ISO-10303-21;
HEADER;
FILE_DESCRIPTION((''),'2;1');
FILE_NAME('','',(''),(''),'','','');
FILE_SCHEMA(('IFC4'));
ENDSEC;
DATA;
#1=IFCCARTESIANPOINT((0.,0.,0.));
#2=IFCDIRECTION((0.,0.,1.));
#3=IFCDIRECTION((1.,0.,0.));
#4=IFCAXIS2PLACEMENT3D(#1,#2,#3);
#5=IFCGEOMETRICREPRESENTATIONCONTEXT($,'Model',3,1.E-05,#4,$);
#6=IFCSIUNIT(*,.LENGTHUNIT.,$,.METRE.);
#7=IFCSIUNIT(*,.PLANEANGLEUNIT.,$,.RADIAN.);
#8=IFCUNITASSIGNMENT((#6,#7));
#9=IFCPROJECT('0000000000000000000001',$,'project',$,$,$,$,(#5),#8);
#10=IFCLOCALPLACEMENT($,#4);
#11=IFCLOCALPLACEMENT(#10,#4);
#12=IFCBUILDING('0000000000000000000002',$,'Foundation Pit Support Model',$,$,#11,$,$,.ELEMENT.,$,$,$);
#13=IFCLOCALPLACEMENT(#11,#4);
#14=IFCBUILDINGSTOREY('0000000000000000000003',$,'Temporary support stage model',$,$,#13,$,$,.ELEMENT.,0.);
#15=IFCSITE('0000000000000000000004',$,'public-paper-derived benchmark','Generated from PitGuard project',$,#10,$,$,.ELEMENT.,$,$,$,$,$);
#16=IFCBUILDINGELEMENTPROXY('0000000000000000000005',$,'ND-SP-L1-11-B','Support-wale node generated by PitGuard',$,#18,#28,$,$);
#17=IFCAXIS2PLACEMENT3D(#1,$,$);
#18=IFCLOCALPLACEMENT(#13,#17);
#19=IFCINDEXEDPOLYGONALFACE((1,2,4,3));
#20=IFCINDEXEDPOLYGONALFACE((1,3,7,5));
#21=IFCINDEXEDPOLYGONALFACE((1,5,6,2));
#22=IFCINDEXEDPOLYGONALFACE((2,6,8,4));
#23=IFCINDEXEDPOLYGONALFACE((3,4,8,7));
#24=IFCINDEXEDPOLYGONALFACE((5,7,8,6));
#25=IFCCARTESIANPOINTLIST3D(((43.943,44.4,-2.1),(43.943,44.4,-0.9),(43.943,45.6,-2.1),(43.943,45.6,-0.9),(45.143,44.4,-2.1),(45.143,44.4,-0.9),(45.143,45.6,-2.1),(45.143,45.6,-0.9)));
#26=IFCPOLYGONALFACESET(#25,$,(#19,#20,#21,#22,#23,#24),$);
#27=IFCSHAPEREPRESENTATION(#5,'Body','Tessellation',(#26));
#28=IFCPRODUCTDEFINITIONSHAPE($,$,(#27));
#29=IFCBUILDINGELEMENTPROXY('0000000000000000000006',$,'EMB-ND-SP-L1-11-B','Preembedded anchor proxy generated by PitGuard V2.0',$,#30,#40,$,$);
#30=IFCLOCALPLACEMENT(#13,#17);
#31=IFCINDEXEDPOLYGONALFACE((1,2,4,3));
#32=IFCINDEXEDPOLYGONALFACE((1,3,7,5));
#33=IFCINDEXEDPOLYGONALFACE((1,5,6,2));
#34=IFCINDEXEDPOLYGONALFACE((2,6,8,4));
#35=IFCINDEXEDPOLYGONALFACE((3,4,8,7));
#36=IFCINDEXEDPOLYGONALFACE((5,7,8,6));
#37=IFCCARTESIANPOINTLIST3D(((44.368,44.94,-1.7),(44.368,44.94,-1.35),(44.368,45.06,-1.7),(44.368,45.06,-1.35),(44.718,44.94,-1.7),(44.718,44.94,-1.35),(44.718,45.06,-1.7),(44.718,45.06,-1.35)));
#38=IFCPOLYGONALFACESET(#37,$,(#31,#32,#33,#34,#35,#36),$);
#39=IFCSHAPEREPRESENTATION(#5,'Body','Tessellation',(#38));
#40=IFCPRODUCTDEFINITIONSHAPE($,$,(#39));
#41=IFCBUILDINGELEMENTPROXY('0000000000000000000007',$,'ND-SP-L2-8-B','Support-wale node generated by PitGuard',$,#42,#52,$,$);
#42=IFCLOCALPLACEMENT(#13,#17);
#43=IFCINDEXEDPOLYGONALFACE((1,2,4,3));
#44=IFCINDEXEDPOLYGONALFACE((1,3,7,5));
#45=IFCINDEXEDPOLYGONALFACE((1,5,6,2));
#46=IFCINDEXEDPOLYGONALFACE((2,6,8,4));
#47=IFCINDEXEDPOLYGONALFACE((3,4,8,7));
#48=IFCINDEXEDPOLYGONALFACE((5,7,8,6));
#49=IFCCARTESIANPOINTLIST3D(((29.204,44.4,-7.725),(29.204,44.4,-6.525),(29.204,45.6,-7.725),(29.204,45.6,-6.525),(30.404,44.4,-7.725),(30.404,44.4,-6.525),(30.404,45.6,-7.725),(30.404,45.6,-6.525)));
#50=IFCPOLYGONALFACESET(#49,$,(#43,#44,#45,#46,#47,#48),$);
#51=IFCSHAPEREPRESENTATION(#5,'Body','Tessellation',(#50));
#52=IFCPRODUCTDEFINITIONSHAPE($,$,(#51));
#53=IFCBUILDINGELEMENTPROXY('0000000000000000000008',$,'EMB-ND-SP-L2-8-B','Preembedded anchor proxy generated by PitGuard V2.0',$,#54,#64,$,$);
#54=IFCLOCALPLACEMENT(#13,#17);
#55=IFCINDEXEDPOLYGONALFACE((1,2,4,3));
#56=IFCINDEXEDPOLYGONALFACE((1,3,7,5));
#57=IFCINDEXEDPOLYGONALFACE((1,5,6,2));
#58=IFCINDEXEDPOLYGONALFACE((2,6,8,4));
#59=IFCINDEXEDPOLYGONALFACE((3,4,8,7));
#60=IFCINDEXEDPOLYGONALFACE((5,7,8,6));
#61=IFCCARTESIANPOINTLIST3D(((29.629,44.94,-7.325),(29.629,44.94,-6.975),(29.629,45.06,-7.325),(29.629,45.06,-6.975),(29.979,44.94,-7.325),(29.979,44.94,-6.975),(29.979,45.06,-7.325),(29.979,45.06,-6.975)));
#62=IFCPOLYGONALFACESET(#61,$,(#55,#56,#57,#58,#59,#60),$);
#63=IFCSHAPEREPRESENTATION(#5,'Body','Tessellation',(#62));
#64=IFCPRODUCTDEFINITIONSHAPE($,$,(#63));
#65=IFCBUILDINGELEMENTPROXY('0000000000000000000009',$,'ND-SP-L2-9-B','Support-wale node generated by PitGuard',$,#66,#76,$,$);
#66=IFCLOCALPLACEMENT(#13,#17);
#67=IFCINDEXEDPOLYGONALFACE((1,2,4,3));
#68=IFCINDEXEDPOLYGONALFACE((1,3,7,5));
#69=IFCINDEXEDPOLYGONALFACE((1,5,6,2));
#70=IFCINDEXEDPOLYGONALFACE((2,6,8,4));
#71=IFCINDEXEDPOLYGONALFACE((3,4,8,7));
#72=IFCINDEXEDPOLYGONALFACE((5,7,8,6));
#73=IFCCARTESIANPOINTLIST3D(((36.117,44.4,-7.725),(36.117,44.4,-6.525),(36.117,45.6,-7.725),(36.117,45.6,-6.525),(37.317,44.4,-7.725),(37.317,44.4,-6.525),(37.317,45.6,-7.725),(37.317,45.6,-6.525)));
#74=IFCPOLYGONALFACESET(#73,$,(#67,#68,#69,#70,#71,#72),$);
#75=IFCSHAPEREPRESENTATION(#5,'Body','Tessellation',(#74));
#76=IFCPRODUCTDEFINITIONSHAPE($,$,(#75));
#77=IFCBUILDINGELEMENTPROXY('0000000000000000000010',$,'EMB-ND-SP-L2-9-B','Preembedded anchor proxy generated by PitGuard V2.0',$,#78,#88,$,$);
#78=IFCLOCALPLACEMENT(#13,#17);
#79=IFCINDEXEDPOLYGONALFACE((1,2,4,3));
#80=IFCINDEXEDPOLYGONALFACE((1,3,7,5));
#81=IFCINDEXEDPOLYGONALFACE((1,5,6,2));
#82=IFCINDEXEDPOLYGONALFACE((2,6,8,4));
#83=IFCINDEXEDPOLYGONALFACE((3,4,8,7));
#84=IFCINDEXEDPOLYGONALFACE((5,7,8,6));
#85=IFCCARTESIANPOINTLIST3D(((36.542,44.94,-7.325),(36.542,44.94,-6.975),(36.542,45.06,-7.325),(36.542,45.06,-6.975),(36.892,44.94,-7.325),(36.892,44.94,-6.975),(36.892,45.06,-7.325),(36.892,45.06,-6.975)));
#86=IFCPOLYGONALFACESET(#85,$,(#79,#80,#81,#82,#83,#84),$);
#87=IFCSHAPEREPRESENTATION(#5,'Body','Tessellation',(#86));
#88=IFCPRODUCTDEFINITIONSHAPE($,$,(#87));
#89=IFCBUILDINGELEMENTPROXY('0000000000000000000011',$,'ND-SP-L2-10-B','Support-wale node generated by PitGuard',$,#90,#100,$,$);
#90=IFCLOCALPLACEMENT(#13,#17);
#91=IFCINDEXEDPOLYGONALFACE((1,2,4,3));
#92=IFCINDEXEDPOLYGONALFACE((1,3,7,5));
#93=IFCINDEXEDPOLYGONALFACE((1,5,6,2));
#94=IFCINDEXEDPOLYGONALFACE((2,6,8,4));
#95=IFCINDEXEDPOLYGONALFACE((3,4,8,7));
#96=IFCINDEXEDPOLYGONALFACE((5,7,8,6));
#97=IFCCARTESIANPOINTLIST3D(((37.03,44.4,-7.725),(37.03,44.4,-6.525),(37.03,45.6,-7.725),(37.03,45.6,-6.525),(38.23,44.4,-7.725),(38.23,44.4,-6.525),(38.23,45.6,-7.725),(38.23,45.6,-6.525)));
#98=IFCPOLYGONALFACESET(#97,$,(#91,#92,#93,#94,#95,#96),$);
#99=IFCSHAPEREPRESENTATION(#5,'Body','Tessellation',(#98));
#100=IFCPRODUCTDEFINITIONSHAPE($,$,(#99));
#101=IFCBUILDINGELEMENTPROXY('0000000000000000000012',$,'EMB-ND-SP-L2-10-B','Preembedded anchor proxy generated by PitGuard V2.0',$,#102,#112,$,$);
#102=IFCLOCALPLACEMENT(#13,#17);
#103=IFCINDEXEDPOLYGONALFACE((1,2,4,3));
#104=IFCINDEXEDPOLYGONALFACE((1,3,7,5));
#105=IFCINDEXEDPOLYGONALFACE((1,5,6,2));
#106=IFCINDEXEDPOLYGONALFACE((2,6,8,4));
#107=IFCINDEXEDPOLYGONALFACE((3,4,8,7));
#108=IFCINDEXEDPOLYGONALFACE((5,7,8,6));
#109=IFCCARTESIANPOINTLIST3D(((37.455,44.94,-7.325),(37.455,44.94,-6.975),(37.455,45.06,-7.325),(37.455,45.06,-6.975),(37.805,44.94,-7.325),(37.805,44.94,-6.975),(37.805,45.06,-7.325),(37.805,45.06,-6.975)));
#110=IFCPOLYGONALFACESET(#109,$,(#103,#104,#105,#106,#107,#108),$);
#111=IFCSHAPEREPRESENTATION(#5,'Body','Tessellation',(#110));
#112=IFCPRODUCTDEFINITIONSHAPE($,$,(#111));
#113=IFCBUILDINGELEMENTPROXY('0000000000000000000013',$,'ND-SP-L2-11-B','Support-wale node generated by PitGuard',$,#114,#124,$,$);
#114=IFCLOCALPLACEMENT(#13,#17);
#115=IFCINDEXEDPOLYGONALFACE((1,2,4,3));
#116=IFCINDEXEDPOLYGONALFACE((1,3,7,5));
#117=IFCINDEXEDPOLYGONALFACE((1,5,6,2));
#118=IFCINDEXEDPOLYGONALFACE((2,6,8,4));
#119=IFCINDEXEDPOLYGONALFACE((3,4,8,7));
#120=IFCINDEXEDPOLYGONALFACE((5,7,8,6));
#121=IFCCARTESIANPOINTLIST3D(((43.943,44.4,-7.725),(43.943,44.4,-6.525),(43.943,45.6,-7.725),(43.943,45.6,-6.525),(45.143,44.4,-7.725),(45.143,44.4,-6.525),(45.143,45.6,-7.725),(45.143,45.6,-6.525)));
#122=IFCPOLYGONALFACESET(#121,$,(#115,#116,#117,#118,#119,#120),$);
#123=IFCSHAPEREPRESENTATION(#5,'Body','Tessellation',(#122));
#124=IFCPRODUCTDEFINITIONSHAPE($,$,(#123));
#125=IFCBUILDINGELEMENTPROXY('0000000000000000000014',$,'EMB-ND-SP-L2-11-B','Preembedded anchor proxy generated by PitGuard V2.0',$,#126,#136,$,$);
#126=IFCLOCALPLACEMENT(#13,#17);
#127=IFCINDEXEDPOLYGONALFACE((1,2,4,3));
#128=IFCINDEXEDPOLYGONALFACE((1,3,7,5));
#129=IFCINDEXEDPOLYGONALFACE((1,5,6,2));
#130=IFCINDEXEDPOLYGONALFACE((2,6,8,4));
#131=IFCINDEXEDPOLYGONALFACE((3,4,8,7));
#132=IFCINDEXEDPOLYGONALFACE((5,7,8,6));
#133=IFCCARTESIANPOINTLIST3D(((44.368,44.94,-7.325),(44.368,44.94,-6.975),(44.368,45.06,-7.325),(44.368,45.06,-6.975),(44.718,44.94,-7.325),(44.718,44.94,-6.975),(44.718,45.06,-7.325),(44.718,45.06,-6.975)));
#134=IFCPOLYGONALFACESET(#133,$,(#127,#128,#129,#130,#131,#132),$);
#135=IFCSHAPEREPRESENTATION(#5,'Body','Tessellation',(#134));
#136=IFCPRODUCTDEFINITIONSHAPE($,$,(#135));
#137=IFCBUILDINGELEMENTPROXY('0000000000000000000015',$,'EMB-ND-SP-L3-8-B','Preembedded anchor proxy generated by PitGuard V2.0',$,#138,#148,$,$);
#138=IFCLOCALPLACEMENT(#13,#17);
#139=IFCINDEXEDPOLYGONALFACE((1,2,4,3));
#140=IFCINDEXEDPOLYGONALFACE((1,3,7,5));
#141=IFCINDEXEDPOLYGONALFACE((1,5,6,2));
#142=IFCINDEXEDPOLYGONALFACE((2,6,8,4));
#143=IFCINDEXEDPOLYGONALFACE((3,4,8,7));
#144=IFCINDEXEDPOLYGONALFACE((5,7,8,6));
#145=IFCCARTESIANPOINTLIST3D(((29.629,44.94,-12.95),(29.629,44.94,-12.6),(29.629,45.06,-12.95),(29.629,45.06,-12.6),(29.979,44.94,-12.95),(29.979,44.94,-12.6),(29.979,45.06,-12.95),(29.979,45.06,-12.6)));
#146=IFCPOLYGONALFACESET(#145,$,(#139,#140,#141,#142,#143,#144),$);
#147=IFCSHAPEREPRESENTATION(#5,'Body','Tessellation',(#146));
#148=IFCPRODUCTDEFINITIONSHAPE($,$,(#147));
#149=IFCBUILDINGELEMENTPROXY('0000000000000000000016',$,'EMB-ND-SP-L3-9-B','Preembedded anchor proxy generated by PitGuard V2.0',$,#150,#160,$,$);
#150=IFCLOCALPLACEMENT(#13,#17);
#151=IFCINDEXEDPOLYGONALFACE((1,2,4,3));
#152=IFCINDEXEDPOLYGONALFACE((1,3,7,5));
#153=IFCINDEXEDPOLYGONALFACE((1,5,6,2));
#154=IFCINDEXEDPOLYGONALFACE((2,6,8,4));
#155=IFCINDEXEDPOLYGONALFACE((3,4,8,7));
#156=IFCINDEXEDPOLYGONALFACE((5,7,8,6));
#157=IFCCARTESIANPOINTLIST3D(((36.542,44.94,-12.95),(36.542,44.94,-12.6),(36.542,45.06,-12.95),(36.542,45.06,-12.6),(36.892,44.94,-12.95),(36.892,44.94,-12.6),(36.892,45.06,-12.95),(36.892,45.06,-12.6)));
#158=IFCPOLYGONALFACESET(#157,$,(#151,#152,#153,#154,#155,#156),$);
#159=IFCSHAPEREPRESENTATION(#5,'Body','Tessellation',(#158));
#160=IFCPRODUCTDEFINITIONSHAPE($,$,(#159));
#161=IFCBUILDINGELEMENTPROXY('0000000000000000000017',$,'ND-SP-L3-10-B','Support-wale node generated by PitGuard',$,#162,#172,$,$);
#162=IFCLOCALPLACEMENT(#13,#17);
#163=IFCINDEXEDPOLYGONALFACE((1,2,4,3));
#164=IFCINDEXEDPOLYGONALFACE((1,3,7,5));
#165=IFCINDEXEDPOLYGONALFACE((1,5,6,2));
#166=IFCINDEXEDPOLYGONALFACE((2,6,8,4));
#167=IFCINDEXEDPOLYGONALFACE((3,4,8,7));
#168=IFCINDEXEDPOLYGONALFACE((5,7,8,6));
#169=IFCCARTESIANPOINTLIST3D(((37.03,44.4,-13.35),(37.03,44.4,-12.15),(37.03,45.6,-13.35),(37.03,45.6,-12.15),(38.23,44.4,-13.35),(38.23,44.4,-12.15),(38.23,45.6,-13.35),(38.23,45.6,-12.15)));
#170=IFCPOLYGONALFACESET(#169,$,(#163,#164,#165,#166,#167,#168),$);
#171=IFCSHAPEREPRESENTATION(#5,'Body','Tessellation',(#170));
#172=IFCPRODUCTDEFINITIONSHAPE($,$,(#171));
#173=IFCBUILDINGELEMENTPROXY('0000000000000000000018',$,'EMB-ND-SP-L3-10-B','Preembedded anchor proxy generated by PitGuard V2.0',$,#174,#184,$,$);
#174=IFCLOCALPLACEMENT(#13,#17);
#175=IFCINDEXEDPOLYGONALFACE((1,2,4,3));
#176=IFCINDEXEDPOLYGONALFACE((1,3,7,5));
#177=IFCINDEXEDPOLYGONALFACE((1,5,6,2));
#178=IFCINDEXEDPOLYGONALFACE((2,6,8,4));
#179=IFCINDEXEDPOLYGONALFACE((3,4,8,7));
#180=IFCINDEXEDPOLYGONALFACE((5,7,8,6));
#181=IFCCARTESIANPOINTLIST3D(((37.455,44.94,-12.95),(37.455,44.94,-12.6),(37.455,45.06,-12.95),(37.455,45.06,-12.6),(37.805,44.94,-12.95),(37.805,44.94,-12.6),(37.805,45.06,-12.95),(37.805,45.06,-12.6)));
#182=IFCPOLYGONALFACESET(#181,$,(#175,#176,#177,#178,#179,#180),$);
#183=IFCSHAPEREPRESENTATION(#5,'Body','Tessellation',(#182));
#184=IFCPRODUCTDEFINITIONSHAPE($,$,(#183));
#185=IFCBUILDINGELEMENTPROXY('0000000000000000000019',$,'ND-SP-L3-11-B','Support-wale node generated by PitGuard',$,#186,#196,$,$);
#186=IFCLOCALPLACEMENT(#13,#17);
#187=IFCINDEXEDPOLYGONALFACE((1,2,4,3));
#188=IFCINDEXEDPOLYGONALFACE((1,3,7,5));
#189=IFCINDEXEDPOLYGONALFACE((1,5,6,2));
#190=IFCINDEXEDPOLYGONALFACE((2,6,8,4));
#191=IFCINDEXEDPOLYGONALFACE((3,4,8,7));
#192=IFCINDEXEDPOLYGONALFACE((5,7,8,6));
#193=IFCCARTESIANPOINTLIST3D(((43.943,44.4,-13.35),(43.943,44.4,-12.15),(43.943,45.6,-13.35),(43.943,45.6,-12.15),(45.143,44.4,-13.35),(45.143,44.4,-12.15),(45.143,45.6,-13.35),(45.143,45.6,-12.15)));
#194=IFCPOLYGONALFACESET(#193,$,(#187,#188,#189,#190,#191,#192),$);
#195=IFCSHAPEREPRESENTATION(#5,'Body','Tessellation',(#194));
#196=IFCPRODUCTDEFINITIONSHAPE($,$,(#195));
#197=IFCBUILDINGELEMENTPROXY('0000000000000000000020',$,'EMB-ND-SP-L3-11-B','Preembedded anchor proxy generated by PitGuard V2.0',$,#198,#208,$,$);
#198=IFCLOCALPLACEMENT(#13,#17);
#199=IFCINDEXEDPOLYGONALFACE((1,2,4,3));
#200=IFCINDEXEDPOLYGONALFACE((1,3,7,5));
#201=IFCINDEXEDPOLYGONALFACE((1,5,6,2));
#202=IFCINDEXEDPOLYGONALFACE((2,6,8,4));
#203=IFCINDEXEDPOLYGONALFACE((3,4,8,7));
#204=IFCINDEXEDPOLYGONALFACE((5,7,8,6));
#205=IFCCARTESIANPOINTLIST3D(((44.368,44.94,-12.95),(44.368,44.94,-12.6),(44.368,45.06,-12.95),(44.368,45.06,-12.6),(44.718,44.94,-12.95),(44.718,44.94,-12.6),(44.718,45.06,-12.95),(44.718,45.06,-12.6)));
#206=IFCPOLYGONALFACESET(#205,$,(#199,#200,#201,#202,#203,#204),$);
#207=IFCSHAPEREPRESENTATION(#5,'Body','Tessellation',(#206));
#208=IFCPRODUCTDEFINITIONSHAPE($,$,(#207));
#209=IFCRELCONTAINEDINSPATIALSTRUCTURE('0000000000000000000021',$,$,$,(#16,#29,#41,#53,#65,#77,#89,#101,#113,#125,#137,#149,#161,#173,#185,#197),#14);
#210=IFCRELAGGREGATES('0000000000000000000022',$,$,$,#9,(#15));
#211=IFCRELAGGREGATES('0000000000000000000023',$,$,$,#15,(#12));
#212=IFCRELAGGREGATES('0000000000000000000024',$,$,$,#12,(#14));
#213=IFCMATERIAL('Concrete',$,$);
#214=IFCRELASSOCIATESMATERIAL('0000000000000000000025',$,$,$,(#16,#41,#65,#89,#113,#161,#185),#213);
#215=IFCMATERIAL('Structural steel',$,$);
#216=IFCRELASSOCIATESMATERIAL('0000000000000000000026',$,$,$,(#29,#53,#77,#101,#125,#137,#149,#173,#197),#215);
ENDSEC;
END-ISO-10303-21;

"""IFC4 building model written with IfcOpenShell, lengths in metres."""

from ifc_helpers import new_model, si_unit, frame, origin_with_axes, origin_2d, place, context, project, spatial, rectangle, extrude, material, element, save


model = new_model("IFC4")

# Units and contexts
model_context = context("Model", 3, precision=1e-05, world=origin_with_axes())
ifc_project = project(units=[si_unit("LENGTHUNIT", "METRE"), si_unit("PLANEANGLEUNIT", "RADIAN")], contexts=[model_context])

# Site, building, storey
site_placement = place(None, origin_with_axes())
site = spatial("IfcSite", under=ifc_project, at=site_placement, Name="public-paper-derived benchmark", Description="Generated from PitGuard project", CompositionType="ELEMENT")
building_placement = place(site_placement, origin_with_axes())
building = spatial("IfcBuilding", under=site, at=building_placement, Name="Foundation Pit Support Model", CompositionType="ELEMENT")
storey_placement = place(building_placement, origin_with_axes())
storey = spatial("IfcBuildingStorey", under=building, at=storey_placement, Name="Temporary support stage model", CompositionType="ELEMENT", Elevation=0.0)

# Shared definitions
ifc_material_1 = material(Name="Structural steel")

# Building element proxies
ifc_material_2 = material(Name="Concrete")
proxy_1_placement = place(storey_placement, frame((44.543, 45.0, -2.1), z_axis=(0.0, 0.0, 1.0), x_axis=(1.0, 0.0, 0.0)))
element("IfcBuildingElementProxy", 1, at=proxy_1_placement, inside=storey, material=ifc_material_2, Name="ND-SP-L1-11-B", Description="Support-wale node generated by PitGuard", context=model_context, shape_type="SweptSolid", body=[
    extrude(rectangle(XDim=1.2, YDim=1.2, at=origin_2d()), origin_with_axes(), (0.0, 0.0, 1.0), 1.2),
])
proxy_2_placement = place(storey_placement, frame((44.543, 45.0, -1.7), z_axis=(0.0, 0.0, 1.0), x_axis=(1.0, 0.0, 0.0)))
element("IfcBuildingElementProxy", 2, at=proxy_2_placement, inside=storey, material=ifc_material_1, Name="EMB-ND-SP-L1-11-B", Description="Preembedded anchor proxy generated by PitGuard V2.0", context=model_context, shape_type="SweptSolid", body=[
    extrude(rectangle(XDim=0.35, YDim=0.12, at=origin_2d()), origin_with_axes(), (0.0, 0.0, 1.0), 0.35),
])
proxy_3_placement = place(storey_placement, frame((29.804, 45.0, -7.725), z_axis=(0.0, 0.0, 1.0), x_axis=(1.0, 0.0, 0.0)))
element("IfcBuildingElementProxy", 3, at=proxy_3_placement, inside=storey, material=ifc_material_2, Name="ND-SP-L2-8-B", Description="Support-wale node generated by PitGuard", context=model_context, shape_type="SweptSolid", body=[
    extrude(rectangle(XDim=1.2, YDim=1.2, at=origin_2d()), origin_with_axes(), (0.0, 0.0, 1.0), 1.2),
])
proxy_4_placement = place(storey_placement, frame((29.804, 45.0, -7.325), z_axis=(0.0, 0.0, 1.0), x_axis=(1.0, 0.0, 0.0)))
element("IfcBuildingElementProxy", 4, at=proxy_4_placement, inside=storey, material=ifc_material_1, Name="EMB-ND-SP-L2-8-B", Description="Preembedded anchor proxy generated by PitGuard V2.0", context=model_context, shape_type="SweptSolid", body=[
    extrude(rectangle(XDim=0.35, YDim=0.12, at=origin_2d()), origin_with_axes(), (0.0, 0.0, 1.0), 0.35),
])
proxy_5_placement = place(storey_placement, frame((36.717, 45.0, -7.725), z_axis=(0.0, 0.0, 1.0), x_axis=(1.0, 0.0, 0.0)))
element("IfcBuildingElementProxy", 5, at=proxy_5_placement, inside=storey, material=ifc_material_2, Name="ND-SP-L2-9-B", Description="Support-wale node generated by PitGuard", context=model_context, shape_type="SweptSolid", body=[
    extrude(rectangle(XDim=1.2, YDim=1.2, at=origin_2d()), origin_with_axes(), (0.0, 0.0, 1.0), 1.2),
])
proxy_6_placement = place(storey_placement, frame((36.717, 45.0, -7.325), z_axis=(0.0, 0.0, 1.0), x_axis=(1.0, 0.0, 0.0)))
element("IfcBuildingElementProxy", 6, at=proxy_6_placement, inside=storey, material=ifc_material_1, Name="EMB-ND-SP-L2-9-B", Description="Preembedded anchor proxy generated by PitGuard V2.0", context=model_context, shape_type="SweptSolid", body=[
    extrude(rectangle(XDim=0.35, YDim=0.12, at=origin_2d()), origin_with_axes(), (0.0, 0.0, 1.0), 0.35),
])
proxy_7_placement = place(storey_placement, frame((37.63, 45.0, -7.725), z_axis=(0.0, 0.0, 1.0), x_axis=(1.0, 0.0, 0.0)))
element("IfcBuildingElementProxy", 7, at=proxy_7_placement, inside=storey, material=ifc_material_2, Name="ND-SP-L2-10-B", Description="Support-wale node generated by PitGuard", context=model_context, shape_type="SweptSolid", body=[
    extrude(rectangle(XDim=1.2, YDim=1.2, at=origin_2d()), origin_with_axes(), (0.0, 0.0, 1.0), 1.2),
])
proxy_8_placement = place(storey_placement, frame((37.63, 45.0, -7.325), z_axis=(0.0, 0.0, 1.0), x_axis=(1.0, 0.0, 0.0)))
element("IfcBuildingElementProxy", 8, at=proxy_8_placement, inside=storey, material=ifc_material_1, Name="EMB-ND-SP-L2-10-B", Description="Preembedded anchor proxy generated by PitGuard V2.0", context=model_context, shape_type="SweptSolid", body=[
    extrude(rectangle(XDim=0.35, YDim=0.12, at=origin_2d()), origin_with_axes(), (0.0, 0.0, 1.0), 0.35),
])
proxy_9_placement = place(storey_placement, frame((44.543, 45.0, -7.725), z_axis=(0.0, 0.0, 1.0), x_axis=(1.0, 0.0, 0.0)))
element("IfcBuildingElementProxy", 9, at=proxy_9_placement, inside=storey, material=ifc_material_2, Name="ND-SP-L2-11-B", Description="Support-wale node generated by PitGuard", context=model_context, shape_type="SweptSolid", body=[
    extrude(rectangle(XDim=1.2, YDim=1.2, at=origin_2d()), origin_with_axes(), (0.0, 0.0, 1.0), 1.2),
])
for number, where, z_axis, x_axis, name in (
    (10, (44.543, 45.0, -7.325), (0.0, 0.0, 1.0), (1.0, 0.0, 0.0), "EMB-ND-SP-L2-11-B"),
    (11, (29.804, 45.0, -12.95), (0.0, 0.0, 1.0), (1.0, 0.0, 0.0), "EMB-ND-SP-L3-8-B"),
    (12, (36.717, 45.0, -12.95), (0.0, 0.0, 1.0), (1.0, 0.0, 0.0), "EMB-ND-SP-L3-9-B"),
):
    element("IfcBuildingElementProxy", number, at=place(storey_placement, frame(where, z_axis=z_axis, x_axis=x_axis)), inside=storey, material=ifc_material_1, Name=name, Description="Preembedded anchor proxy generated by PitGuard V2.0", context=model_context, shape_type="SweptSolid", body=[
        extrude(rectangle(XDim=0.35, YDim=0.12, at=origin_2d()), origin_with_axes(), (0.0, 0.0, 1.0), 0.35),
    ])
proxy_10_placement = place(storey_placement, frame((37.63, 45.0, -13.35), z_axis=(0.0, 0.0, 1.0), x_axis=(1.0, 0.0, 0.0)))
element("IfcBuildingElementProxy", 13, at=proxy_10_placement, inside=storey, material=ifc_material_2, Name="ND-SP-L3-10-B", Description="Support-wale node generated by PitGuard", context=model_context, shape_type="SweptSolid", body=[
    extrude(rectangle(XDim=1.2, YDim=1.2, at=origin_2d()), origin_with_axes(), (0.0, 0.0, 1.0), 1.2),
])
proxy_11_placement = place(storey_placement, frame((37.63, 45.0, -12.95), z_axis=(0.0, 0.0, 1.0), x_axis=(1.0, 0.0, 0.0)))
element("IfcBuildingElementProxy", 14, at=proxy_11_placement, inside=storey, material=ifc_material_1, Name="EMB-ND-SP-L3-10-B", Description="Preembedded anchor proxy generated by PitGuard V2.0", context=model_context, shape_type="SweptSolid", body=[
    extrude(rectangle(XDim=0.35, YDim=0.12, at=origin_2d()), origin_with_axes(), (0.0, 0.0, 1.0), 0.35),
])
proxy_12_placement = place(storey_placement, frame((44.543, 45.0, -13.35), z_axis=(0.0, 0.0, 1.0), x_axis=(1.0, 0.0, 0.0)))
element("IfcBuildingElementProxy", 15, at=proxy_12_placement, inside=storey, material=ifc_material_2, Name="ND-SP-L3-11-B", Description="Support-wale node generated by PitGuard", context=model_context, shape_type="SweptSolid", body=[
    extrude(rectangle(XDim=1.2, YDim=1.2, at=origin_2d()), origin_with_axes(), (0.0, 0.0, 1.0), 1.2),
])
proxy_13_placement = place(storey_placement, frame((44.543, 45.0, -12.95), z_axis=(0.0, 0.0, 1.0), x_axis=(1.0, 0.0, 0.0)))
element("IfcBuildingElementProxy", 16, at=proxy_13_placement, inside=storey, material=ifc_material_1, Name="EMB-ND-SP-L3-11-B", Description="Preembedded anchor proxy generated by PitGuard V2.0", context=model_context, shape_type="SweptSolid", body=[
    extrude(rectangle(XDim=0.35, YDim=0.12, at=origin_2d()), origin_with_axes(), (0.0, 0.0, 1.0), 0.35),
])

save(model, "model.ifc")
